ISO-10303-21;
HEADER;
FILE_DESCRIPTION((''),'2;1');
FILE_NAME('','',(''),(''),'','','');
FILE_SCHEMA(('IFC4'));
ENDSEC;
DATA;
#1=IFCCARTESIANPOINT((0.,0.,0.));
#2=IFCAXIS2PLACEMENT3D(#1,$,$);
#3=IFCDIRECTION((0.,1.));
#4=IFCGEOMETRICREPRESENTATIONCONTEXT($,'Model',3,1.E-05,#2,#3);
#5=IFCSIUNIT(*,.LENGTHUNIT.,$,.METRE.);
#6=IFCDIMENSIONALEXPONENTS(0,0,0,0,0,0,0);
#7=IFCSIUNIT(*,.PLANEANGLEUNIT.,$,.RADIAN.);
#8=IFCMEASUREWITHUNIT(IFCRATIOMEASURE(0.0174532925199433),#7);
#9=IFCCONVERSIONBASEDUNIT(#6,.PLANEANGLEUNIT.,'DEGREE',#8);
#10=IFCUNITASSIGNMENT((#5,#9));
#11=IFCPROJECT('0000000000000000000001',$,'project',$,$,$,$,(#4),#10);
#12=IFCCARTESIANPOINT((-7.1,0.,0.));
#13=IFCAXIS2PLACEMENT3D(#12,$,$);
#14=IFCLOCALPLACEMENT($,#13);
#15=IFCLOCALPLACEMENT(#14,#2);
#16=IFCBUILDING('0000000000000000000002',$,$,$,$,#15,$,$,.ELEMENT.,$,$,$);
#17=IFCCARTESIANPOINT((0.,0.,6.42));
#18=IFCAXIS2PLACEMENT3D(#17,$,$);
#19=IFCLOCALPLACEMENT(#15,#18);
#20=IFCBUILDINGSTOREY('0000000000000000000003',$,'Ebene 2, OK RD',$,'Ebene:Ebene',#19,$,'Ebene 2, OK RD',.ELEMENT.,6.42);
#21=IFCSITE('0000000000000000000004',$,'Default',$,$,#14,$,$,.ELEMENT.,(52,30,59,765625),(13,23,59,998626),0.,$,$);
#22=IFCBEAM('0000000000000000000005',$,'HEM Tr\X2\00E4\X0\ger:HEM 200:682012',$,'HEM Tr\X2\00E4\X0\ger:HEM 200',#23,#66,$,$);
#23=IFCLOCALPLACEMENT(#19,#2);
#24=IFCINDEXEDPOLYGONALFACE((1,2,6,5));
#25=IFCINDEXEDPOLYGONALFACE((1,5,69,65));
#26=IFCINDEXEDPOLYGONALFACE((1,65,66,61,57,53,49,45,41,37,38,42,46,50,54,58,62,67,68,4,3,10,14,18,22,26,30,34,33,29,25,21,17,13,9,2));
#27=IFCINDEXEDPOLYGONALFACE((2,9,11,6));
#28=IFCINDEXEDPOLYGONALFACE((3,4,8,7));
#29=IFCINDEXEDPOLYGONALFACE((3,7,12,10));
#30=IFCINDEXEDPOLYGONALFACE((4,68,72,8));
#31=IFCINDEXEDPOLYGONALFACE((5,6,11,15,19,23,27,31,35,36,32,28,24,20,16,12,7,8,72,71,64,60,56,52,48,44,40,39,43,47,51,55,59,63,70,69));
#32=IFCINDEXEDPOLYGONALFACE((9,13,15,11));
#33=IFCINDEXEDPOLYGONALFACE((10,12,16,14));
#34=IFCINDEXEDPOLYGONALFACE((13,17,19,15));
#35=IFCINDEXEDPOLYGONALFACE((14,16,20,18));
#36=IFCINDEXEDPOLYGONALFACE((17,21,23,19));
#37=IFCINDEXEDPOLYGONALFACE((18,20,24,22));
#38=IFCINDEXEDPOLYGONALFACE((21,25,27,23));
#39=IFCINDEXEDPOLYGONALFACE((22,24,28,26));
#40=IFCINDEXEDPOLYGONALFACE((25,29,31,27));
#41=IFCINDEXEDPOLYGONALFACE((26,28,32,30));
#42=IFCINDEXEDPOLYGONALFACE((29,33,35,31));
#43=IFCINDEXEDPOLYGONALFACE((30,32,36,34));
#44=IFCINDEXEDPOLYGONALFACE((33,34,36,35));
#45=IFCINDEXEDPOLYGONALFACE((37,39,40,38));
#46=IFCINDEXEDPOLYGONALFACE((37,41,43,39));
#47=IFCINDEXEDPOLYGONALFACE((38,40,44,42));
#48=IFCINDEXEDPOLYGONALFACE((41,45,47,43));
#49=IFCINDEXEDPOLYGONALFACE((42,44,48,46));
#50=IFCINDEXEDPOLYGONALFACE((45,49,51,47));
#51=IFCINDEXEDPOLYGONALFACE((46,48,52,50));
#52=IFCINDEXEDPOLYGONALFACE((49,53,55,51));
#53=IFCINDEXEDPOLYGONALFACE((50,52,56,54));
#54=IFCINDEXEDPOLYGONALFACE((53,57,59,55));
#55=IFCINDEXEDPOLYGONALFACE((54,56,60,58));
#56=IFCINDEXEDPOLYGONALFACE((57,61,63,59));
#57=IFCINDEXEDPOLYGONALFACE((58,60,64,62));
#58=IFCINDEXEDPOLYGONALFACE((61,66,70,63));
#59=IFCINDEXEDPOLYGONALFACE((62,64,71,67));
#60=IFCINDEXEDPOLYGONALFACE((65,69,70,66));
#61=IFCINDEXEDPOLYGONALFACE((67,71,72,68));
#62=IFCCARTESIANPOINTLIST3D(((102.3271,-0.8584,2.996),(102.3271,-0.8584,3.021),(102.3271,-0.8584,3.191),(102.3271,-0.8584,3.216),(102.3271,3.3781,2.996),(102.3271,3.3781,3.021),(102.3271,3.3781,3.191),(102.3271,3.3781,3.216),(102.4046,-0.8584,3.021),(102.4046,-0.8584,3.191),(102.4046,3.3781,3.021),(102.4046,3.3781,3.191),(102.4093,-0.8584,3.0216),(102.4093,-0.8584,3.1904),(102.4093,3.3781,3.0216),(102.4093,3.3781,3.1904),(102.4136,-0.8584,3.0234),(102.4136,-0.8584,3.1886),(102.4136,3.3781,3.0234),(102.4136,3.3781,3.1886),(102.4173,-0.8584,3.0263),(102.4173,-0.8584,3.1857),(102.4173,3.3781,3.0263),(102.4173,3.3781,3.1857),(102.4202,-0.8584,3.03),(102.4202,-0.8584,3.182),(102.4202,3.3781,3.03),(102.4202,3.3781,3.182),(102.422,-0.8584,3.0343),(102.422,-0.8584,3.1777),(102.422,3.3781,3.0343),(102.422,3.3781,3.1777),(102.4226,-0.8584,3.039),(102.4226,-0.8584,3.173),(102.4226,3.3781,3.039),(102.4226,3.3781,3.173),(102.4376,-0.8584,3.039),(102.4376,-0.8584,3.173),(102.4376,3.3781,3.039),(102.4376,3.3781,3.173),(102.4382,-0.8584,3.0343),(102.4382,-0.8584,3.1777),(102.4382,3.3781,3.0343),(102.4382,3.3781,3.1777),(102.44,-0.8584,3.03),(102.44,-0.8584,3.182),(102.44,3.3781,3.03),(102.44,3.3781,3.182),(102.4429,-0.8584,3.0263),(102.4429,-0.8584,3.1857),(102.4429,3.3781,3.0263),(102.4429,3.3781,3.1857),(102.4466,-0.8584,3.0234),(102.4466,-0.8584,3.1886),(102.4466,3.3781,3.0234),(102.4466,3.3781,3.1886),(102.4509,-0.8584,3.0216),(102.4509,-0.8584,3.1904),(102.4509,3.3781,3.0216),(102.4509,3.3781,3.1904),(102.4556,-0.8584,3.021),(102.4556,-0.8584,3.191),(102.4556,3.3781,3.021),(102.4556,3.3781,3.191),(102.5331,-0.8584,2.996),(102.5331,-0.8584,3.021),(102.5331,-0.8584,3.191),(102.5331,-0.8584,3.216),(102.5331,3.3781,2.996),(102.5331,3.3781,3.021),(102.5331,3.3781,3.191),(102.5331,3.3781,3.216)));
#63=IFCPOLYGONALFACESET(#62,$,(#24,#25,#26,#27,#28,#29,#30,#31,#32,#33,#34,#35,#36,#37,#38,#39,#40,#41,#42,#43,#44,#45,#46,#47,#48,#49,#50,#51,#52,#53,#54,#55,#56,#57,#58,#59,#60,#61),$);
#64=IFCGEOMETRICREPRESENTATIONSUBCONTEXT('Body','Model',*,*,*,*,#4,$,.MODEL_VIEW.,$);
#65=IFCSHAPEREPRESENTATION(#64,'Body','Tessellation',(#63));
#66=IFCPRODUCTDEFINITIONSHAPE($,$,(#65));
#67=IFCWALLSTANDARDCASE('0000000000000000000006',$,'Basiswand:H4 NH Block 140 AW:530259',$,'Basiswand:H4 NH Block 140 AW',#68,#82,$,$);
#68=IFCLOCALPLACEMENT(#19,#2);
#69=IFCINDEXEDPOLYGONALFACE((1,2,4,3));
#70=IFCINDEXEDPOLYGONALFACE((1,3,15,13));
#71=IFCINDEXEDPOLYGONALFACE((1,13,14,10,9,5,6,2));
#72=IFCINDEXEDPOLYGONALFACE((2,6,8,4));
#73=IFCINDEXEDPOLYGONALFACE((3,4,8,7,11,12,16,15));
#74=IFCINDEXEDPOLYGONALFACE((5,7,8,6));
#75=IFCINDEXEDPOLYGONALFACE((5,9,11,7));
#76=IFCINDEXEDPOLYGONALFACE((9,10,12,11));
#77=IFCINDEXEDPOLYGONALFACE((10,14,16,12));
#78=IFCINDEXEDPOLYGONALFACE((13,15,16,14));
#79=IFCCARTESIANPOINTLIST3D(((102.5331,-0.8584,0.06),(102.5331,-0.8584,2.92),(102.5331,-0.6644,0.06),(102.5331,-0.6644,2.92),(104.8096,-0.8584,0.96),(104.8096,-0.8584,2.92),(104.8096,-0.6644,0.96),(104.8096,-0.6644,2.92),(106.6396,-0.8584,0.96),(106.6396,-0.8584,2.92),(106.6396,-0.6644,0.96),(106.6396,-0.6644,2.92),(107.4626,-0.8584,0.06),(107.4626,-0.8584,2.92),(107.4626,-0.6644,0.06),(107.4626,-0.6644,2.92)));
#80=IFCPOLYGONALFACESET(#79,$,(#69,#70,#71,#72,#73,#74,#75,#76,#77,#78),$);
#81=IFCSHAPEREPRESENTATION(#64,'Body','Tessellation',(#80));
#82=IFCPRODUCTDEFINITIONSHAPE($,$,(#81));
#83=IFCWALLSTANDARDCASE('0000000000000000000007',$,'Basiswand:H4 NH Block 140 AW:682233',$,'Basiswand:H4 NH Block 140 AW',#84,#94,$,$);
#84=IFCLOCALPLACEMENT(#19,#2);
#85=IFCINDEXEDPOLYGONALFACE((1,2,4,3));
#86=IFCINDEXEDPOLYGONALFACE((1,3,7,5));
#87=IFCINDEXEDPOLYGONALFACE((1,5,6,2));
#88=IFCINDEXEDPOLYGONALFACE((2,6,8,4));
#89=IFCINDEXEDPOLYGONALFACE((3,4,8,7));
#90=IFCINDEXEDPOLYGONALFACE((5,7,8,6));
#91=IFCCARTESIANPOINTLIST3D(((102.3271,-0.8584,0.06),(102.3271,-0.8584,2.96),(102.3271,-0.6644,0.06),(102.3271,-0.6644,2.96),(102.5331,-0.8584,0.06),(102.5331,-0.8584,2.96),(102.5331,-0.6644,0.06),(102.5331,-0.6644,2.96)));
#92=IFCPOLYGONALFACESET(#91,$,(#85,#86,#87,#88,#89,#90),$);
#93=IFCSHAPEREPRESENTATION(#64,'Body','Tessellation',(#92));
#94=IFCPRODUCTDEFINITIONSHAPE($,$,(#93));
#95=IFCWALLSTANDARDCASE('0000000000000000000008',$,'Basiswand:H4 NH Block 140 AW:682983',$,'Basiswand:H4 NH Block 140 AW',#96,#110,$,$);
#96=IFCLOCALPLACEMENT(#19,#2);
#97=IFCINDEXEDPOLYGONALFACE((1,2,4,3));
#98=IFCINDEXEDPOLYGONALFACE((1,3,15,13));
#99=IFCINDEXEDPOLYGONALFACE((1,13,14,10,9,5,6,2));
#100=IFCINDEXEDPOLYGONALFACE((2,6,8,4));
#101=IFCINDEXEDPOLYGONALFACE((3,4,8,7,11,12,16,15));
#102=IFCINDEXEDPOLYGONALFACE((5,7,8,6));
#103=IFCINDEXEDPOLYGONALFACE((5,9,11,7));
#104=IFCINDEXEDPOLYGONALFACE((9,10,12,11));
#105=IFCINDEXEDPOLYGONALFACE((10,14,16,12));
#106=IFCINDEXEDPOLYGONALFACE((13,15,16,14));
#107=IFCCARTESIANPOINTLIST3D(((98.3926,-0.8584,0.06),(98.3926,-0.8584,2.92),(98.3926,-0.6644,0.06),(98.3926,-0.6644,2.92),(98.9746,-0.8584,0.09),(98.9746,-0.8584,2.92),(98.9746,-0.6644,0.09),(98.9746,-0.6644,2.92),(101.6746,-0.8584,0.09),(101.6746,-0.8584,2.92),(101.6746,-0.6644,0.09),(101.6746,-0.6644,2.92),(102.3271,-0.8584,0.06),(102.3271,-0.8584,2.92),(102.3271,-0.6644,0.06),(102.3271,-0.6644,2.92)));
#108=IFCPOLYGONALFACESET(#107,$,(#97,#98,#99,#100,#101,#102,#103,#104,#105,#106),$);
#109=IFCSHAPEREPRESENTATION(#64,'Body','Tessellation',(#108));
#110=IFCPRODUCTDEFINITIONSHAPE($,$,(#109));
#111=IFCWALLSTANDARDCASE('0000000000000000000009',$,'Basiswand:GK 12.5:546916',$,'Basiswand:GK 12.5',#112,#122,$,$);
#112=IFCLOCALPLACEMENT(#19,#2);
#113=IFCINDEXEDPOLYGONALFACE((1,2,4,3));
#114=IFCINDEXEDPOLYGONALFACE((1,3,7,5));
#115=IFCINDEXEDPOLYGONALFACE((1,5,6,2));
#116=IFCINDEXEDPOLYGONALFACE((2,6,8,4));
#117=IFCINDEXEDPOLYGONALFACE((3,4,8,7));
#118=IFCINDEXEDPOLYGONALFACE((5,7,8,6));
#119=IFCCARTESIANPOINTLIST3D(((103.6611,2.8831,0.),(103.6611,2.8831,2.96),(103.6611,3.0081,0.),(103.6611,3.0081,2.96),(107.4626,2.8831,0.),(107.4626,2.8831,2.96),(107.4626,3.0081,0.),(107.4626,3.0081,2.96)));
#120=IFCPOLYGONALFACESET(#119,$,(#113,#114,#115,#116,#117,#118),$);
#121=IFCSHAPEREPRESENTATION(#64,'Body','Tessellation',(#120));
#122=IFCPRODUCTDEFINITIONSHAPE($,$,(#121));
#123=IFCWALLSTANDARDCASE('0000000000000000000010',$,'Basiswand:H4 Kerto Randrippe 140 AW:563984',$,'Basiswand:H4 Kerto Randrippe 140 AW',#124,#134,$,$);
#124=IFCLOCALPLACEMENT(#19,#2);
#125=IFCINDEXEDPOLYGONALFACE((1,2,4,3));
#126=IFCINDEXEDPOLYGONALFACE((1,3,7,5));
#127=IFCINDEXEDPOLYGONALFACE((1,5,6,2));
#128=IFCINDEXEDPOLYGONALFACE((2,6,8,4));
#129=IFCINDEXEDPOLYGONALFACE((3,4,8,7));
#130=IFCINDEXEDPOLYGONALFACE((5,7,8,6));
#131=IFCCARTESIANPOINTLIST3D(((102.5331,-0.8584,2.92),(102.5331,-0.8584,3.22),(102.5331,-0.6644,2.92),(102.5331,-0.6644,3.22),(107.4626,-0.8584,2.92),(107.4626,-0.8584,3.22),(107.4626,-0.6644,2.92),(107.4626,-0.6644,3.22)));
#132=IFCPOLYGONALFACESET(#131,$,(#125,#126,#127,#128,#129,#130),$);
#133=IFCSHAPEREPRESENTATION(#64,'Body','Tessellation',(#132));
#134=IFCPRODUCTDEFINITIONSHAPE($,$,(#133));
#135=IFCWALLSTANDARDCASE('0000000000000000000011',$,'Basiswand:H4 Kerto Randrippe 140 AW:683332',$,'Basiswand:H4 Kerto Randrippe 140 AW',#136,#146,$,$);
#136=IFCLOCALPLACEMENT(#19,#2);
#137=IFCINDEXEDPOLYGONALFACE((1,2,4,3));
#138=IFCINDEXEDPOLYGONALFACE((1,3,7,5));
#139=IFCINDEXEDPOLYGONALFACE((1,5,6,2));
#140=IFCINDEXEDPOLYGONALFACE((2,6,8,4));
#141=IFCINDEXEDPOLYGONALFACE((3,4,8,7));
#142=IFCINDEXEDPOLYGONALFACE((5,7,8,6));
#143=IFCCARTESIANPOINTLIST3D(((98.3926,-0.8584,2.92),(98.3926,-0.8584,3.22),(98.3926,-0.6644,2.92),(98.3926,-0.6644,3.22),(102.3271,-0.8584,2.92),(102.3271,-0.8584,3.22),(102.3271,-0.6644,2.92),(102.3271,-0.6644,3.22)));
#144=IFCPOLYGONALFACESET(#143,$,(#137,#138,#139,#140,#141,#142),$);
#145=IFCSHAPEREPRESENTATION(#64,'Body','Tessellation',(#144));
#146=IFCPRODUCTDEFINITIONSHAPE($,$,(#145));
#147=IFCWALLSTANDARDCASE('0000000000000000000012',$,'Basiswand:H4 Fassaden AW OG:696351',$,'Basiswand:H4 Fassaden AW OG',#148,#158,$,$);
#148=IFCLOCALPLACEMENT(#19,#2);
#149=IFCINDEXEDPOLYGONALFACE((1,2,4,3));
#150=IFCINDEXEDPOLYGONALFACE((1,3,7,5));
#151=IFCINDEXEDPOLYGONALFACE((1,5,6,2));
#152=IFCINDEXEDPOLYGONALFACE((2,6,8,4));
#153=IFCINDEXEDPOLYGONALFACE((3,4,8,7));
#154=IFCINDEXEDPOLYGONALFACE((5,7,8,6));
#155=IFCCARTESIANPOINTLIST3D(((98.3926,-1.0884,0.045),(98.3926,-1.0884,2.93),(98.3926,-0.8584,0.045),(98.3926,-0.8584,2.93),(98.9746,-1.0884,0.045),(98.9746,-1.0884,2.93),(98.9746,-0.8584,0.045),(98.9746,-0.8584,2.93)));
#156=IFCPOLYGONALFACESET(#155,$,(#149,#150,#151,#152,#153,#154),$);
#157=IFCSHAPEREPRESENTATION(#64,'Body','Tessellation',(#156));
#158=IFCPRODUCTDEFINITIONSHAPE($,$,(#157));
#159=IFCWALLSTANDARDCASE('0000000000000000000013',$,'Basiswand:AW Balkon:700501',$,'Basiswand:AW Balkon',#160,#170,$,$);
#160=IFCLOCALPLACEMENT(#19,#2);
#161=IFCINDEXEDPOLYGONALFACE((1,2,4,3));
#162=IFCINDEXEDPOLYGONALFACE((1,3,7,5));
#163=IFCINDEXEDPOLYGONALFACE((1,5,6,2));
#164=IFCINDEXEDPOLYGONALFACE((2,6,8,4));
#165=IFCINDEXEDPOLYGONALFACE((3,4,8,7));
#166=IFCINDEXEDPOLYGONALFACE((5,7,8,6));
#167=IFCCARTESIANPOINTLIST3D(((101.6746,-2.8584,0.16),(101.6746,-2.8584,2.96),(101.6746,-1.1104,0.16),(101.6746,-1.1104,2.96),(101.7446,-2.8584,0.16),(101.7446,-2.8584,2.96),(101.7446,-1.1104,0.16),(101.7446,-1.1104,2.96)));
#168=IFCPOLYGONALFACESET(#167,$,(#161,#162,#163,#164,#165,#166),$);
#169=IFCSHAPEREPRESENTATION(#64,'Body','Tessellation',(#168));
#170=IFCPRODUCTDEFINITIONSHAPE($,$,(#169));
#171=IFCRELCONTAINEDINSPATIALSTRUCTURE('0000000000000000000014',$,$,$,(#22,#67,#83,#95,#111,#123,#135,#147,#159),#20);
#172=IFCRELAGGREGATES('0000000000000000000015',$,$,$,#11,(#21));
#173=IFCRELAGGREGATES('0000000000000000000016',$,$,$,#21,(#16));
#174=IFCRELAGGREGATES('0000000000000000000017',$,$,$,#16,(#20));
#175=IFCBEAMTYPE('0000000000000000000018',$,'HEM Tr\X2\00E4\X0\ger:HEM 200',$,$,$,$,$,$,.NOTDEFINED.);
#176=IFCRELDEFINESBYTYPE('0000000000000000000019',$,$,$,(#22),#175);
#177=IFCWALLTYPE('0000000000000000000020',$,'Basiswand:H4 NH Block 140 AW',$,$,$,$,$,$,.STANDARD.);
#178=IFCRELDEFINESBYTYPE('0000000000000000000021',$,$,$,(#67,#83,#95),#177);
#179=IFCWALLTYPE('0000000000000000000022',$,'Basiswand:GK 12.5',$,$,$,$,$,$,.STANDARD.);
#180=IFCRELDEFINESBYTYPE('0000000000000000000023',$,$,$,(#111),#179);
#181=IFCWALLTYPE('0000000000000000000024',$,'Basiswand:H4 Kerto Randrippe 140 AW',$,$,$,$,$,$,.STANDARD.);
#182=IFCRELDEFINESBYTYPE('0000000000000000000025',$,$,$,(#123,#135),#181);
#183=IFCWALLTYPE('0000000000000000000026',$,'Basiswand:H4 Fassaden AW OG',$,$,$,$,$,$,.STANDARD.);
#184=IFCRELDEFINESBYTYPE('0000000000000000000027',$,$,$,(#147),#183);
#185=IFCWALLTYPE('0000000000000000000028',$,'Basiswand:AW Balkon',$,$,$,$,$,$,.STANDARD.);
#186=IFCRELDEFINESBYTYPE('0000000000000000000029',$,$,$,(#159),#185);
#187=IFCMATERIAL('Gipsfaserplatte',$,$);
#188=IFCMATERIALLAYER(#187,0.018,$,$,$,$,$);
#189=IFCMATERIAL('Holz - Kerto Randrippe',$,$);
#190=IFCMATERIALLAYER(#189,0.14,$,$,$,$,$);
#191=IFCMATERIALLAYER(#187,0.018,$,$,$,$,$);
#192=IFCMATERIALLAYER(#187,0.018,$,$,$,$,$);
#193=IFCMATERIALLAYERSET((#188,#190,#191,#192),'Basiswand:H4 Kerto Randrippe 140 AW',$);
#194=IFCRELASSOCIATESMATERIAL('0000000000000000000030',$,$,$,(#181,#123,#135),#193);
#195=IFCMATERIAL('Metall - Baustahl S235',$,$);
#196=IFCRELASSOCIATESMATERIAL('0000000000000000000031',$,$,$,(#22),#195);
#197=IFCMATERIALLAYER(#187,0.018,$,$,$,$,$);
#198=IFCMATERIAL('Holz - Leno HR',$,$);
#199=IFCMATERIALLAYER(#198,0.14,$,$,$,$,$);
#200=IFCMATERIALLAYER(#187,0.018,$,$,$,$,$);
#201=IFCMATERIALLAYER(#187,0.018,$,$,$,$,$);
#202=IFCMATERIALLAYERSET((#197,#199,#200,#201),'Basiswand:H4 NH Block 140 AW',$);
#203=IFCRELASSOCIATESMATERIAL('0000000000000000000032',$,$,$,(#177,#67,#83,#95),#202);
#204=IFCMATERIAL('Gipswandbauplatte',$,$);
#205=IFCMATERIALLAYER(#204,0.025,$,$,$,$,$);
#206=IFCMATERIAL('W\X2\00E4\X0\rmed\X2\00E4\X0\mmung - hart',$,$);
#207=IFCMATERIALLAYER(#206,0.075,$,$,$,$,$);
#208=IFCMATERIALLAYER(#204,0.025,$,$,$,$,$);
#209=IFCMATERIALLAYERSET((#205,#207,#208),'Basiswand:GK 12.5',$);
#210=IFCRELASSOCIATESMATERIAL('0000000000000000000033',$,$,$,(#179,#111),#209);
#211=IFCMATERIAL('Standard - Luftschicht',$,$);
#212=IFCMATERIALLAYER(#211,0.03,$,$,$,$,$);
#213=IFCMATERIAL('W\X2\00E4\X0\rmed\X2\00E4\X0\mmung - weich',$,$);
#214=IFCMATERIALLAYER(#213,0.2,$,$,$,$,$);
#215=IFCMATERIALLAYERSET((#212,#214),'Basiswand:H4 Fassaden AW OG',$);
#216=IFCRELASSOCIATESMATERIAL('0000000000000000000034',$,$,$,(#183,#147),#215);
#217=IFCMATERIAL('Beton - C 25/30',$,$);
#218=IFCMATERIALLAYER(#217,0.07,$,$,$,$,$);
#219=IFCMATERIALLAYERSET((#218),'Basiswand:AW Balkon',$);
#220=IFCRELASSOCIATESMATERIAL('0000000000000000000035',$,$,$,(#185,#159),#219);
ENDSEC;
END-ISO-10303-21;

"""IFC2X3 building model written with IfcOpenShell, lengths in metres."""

from ifc_helpers import new_model, entity, si_unit, converted_unit, direction, frame, frame_2d, origin, place, context, subcontext, project, spatial, rectangle, i_section, extrude, material, layer, layer_set, layer_usage, type_object, element, save


model = new_model("IFC2X3")

# Units and contexts
model_context = context("Model", 3, precision=1e-05, world=origin(), true_north=direction((0.0, 1.0)))
body_context = subcontext(model_context, "Body", "Model", "MODEL_VIEW")
ifc_project = project(units=[si_unit("LENGTHUNIT", "METRE"), converted_unit("PLANEANGLEUNIT", "DEGREE", entity("IfcRatioMeasure", 0.0174532925199433), si_unit("PLANEANGLEUNIT", "RADIAN"), dimensions=[0, 0, 0, 0, 0, 0, 0])], contexts=[model_context])

# Site, building, storey
site_placement = place(None, frame((-7.1, 0.0, 0.0)))
site = spatial("IfcSite", under=ifc_project, at=site_placement, Name="Default", CompositionType="ELEMENT", RefLatitude=(52, 30, 59, 765625), RefLongitude=(13, 23, 59, 998626), RefElevation=0.0)
building_placement = place(site_placement, origin())
building = spatial("IfcBuilding", under=site, at=building_placement, CompositionType="ELEMENT")
storey_placement = place(building_placement, frame((0.0, 0.0, 6.42)))
storey = spatial("IfcBuildingStorey", under=building, at=storey_placement, Name="Ebene 2, OK RD", ObjectType="Ebene:Ebene", LongName="Ebene 2, OK RD", CompositionType="ELEMENT", Elevation=6.42)

# Shared definitions
ifc_material_1 = material(Name="Gipsfaserplatte")
ifc_layer_1 = layer(ifc_material_1, 0.018)
ifc_material_2 = material(Name="Holz - Kerto Randrippe")
ifc_layer_2 = layer(ifc_material_2, 0.14)
ifc_layer_3 = layer(ifc_material_1, 0.018)
ifc_layer_4 = layer(ifc_material_1, 0.018)
ifc_layer_set_1 = layer_set([ifc_layer_1, ifc_layer_2, ifc_layer_3, ifc_layer_4], Name="Basiswand:H4 Kerto Randrippe 140 AW")
wall_type_1 = type_object("IfcWallType", Name="Basiswand:H4 Kerto Randrippe 140 AW", PredefinedType="STANDARD", material=ifc_layer_set_1)

# Beam
ifc_material_3 = material(Name="Metall - Baustahl S235")
beam_type = type_object("IfcBeamType", Name="HEM Träger:HEM 200", PredefinedType="NOTDEFINED")
beam_placement = place(storey_placement, frame((102.4301, -0.8404, 2.996), z_axis=(0.0, 0.0, 1.0), x_axis=(0.0, 1.0, 0.0)))
element("IfcBeam", 1, at=beam_placement, inside=storey, type_object=beam_type, material=ifc_material_3, Name="HEM Träger:HEM 200:682012", ObjectType="HEM Träger:HEM 200", context=body_context, shape_type="SweptSolid", body=[
    extrude(i_section(OverallWidth=0.206, OverallDepth=0.22, WebThickness=0.015, FlangeThickness=0.025, FilletRadius=0.018, at=frame_2d((0.0, 0.0), x_axis=(0.0, 1.0))), frame((-0.018, 0.0, 0.11), z_axis=(1.0, 0.0, 0.0), x_axis=(0.0, 0.0, -1.0)), (0.0, 0.0, 1.0), 4.2365),
])

# Shared definitions
ifc_material_4 = material(Name="Standard - Luftschicht")
ifc_material_5 = material(Name="Wärmedämmung - weich")

# Wall, opening
ifc_layer_5 = layer(ifc_material_1, 0.018)
ifc_material_6 = material(Name="Holz - Leno HR")
ifc_layer_6 = layer(ifc_material_6, 0.14)
ifc_layer_7 = layer(ifc_material_1, 0.018)
ifc_layer_8 = layer(ifc_material_1, 0.018)
ifc_layer_set_2 = layer_set([ifc_layer_5, ifc_layer_6, ifc_layer_7, ifc_layer_8], Name="Basiswand:H4 NH Block 140 AW")
ifc_layer_usage_1 = layer_usage(ifc_layer_set_2, "AXIS2", "NEGATIVE", 0.097)
wall_type_2 = type_object("IfcWallType", Name="Basiswand:H4 NH Block 140 AW", PredefinedType="STANDARD", material=ifc_layer_set_2)
wall_1_placement = place(storey_placement, frame((107.4626, -0.7614, 0.06), z_axis=(0.0, 0.0, 1.0), x_axis=(-1.0, 0.0, 0.0)))
wall_1 = element("IfcWallStandardCase", 2, at=wall_1_placement, inside=storey, type_object=wall_type_2, material=ifc_layer_usage_1, Name="Basiswand:H4 NH Block 140 AW:530259", ObjectType="Basiswand:H4 NH Block 140 AW", context=body_context, shape_type="SweptSolid", body=[
    extrude(rectangle(XDim=4.9295, YDim=0.194, at=frame_2d((2.4648, 0.0), x_axis=(-1.0, 0.0))), origin(), (0.0, 0.0, 1.0), 2.86),
])
opening_1_placement = place(wall_1_placement, origin())
element("IfcOpeningElement", 3, at=opening_1_placement, cuts=wall_1, ObjectType="Opening", context=body_context, shape_type="SweptSolid", body=[
    extrude(rectangle(XDim=2.0, YDim=1.83, at=frame_2d((0.0, 0.0), x_axis=(1.0, 0.0))), frame((1.738, -0.097, 1.9), z_axis=(0.0, 1.0, 0.0), x_axis=(0.0, 0.0, -1.0)), (0.0, 0.0, 1.0), 0.194),
])

# Wall
ifc_layer_usage_2 = layer_usage(ifc_layer_set_2, "AXIS2", "NEGATIVE", 0.097)
wall_2_placement = place(storey_placement, frame((102.5331, -0.7614, 0.06), z_axis=(0.0, 0.0, 1.0), x_axis=(-1.0, 0.0, 0.0)))
element("IfcWallStandardCase", 4, at=wall_2_placement, inside=storey, type_object=wall_type_2, material=ifc_layer_usage_2, Name="Basiswand:H4 NH Block 140 AW:682233", ObjectType="Basiswand:H4 NH Block 140 AW", context=body_context, shape_type="SweptSolid", body=[
    extrude(rectangle(XDim=0.206, YDim=0.194, at=frame_2d((0.103, 0.0), x_axis=(-1.0, 0.0))), origin(), (0.0, 0.0, 1.0), 2.9),
])

# Wall, opening
ifc_layer_usage_3 = layer_usage(ifc_layer_set_2, "AXIS2", "NEGATIVE", 0.097)
wall_3_placement = place(storey_placement, frame((102.3271, -0.7614, 0.06), z_axis=(0.0, 0.0, 1.0), x_axis=(-1.0, 0.0, 0.0)))
wall_3 = element("IfcWallStandardCase", 5, at=wall_3_placement, inside=storey, type_object=wall_type_2, material=ifc_layer_usage_3, Name="Basiswand:H4 NH Block 140 AW:682983", ObjectType="Basiswand:H4 NH Block 140 AW", context=body_context, shape_type="SweptSolid", body=[
    extrude(rectangle(XDim=3.9345, YDim=0.194, at=frame_2d((1.9672, 0.0), x_axis=(-1.0, 0.0))), origin(), (0.0, 0.0, 1.0), 2.86),
])
opening_2_placement = place(wall_3_placement, origin())
element("IfcOpeningElement", 6, at=opening_2_placement, cuts=wall_3, ObjectType="Opening", context=body_context, shape_type="SweptSolid", body=[
    extrude(rectangle(XDim=2.87, YDim=2.7, at=frame_2d((0.0, 0.0), x_axis=(1.0, 0.0))), frame((2.0025, -0.097, 1.465), z_axis=(0.0, 1.0, 0.0), x_axis=(0.0, 0.0, -1.0)), (0.0, 0.0, 1.0), 0.194),
])

# Walls
ifc_material_7 = material(Name="Gipswandbauplatte")
ifc_layer_9 = layer(ifc_material_7, 0.025)
ifc_material_8 = material(Name="Wärmedämmung - hart")
ifc_layer_10 = layer(ifc_material_8, 0.075)
ifc_layer_11 = layer(ifc_material_7, 0.025)
ifc_layer_set_3 = layer_set([ifc_layer_9, ifc_layer_10, ifc_layer_11], Name="Basiswand:GK 12.5")
ifc_layer_usage_4 = layer_usage(ifc_layer_set_3, "AXIS2", "NEGATIVE", 0.0625)
wall_type_3 = type_object("IfcWallType", Name="Basiswand:GK 12.5", PredefinedType="STANDARD", material=ifc_layer_set_3)
wall_4_placement = place(storey_placement, frame((103.6611, 2.9456, 0.0)))
element("IfcWallStandardCase", 7, at=wall_4_placement, inside=storey, type_object=wall_type_3, material=ifc_layer_usage_4, Name="Basiswand:GK 12.5:546916", ObjectType="Basiswand:GK 12.5", context=body_context, shape_type="SweptSolid", body=[
    extrude(rectangle(XDim=3.8015, YDim=0.125, at=frame_2d((1.9008, 0.0), x_axis=(-1.0, 0.0))), origin(), (0.0, 0.0, 1.0), 2.96),
])
ifc_layer_usage_5 = layer_usage(ifc_layer_set_1, "AXIS2", "NEGATIVE", 0.097)
wall_5_placement = place(storey_placement, frame((107.4626, -0.7614, 2.92), z_axis=(0.0, 0.0, 1.0), x_axis=(-1.0, 0.0, 0.0)))
element("IfcWallStandardCase", 8, at=wall_5_placement, inside=storey, type_object=wall_type_1, material=ifc_layer_usage_5, Name="Basiswand:H4 Kerto Randrippe 140 AW:563984", ObjectType="Basiswand:H4 Kerto Randrippe 140 AW", context=body_context, shape_type="SweptSolid", body=[
    extrude(rectangle(XDim=4.9295, YDim=0.194, at=frame_2d((2.4648, 0.0), x_axis=(-1.0, 0.0))), origin(), (0.0, 0.0, 1.0), 0.3),
])
ifc_layer_usage_6 = layer_usage(ifc_layer_set_1, "AXIS2", "NEGATIVE", 0.097)
wall_6_placement = place(storey_placement, frame((102.3271, -0.7614, 2.92), z_axis=(0.0, 0.0, 1.0), x_axis=(-1.0, 0.0, 0.0)))
element("IfcWallStandardCase", 9, at=wall_6_placement, inside=storey, type_object=wall_type_1, material=ifc_layer_usage_6, Name="Basiswand:H4 Kerto Randrippe 140 AW:683332", ObjectType="Basiswand:H4 Kerto Randrippe 140 AW", context=body_context, shape_type="SweptSolid", body=[
    extrude(rectangle(XDim=3.9345, YDim=0.194, at=frame_2d((1.9672, 0.0), x_axis=(-1.0, 0.0))), origin(), (0.0, 0.0, 1.0), 0.3),
])

# Shared definitions
ifc_layer_12 = layer(ifc_material_4, 0.03)
ifc_layer_13 = layer(ifc_material_5, 0.2)
ifc_layer_set_4 = layer_set([ifc_layer_12, ifc_layer_13], Name="Basiswand:H4 Fassaden AW OG")
wall_type_4 = type_object("IfcWallType", Name="Basiswand:H4 Fassaden AW OG", PredefinedType="STANDARD", material=ifc_layer_set_4)

# Walls
ifc_layer_usage_7 = layer_usage(ifc_layer_set_4, "AXIS2", "NEGATIVE", 0.115)
wall_7_placement = place(storey_placement, frame((98.9746, -0.9734, 0.045), z_axis=(0.0, 0.0, 1.0), x_axis=(-1.0, 0.0, 0.0)))
element("IfcWallStandardCase", 10, at=wall_7_placement, inside=storey, type_object=wall_type_4, material=ifc_layer_usage_7, Name="Basiswand:H4 Fassaden AW OG:696351", ObjectType="Basiswand:H4 Fassaden AW OG", context=body_context, shape_type="SweptSolid", body=[
    extrude(rectangle(XDim=0.582, YDim=0.23, at=frame_2d((0.291, 0.0), x_axis=(-1.0, 0.0))), origin(), (0.0, 0.0, 1.0), 2.885),
])
ifc_material_9 = material(Name="Beton - C 25/30")
ifc_layer_14 = layer(ifc_material_9, 0.07)
ifc_layer_set_5 = layer_set([ifc_layer_14], Name="Basiswand:AW Balkon")
ifc_layer_usage_8 = layer_usage(ifc_layer_set_5, "AXIS2", "NEGATIVE", 0.035)
wall_type_5 = type_object("IfcWallType", Name="Basiswand:AW Balkon", PredefinedType="STANDARD", material=ifc_layer_set_5)
wall_8_placement = place(storey_placement, frame((101.7096, -1.1104, 0.16), z_axis=(0.0, 0.0, 1.0), x_axis=(0.0, -1.0, 0.0)))
element("IfcWallStandardCase", 11, at=wall_8_placement, inside=storey, type_object=wall_type_5, material=ifc_layer_usage_8, Name="Basiswand:AW Balkon:700501", ObjectType="Basiswand:AW Balkon", context=body_context, shape_type="SweptSolid", body=[
    extrude(rectangle(XDim=1.748, YDim=0.07, at=frame_2d((0.874, 0.0), x_axis=(-1.0, 0.0))), origin(), (0.0, 0.0, 1.0), 2.8),
])

save(model, "model.ifc")
